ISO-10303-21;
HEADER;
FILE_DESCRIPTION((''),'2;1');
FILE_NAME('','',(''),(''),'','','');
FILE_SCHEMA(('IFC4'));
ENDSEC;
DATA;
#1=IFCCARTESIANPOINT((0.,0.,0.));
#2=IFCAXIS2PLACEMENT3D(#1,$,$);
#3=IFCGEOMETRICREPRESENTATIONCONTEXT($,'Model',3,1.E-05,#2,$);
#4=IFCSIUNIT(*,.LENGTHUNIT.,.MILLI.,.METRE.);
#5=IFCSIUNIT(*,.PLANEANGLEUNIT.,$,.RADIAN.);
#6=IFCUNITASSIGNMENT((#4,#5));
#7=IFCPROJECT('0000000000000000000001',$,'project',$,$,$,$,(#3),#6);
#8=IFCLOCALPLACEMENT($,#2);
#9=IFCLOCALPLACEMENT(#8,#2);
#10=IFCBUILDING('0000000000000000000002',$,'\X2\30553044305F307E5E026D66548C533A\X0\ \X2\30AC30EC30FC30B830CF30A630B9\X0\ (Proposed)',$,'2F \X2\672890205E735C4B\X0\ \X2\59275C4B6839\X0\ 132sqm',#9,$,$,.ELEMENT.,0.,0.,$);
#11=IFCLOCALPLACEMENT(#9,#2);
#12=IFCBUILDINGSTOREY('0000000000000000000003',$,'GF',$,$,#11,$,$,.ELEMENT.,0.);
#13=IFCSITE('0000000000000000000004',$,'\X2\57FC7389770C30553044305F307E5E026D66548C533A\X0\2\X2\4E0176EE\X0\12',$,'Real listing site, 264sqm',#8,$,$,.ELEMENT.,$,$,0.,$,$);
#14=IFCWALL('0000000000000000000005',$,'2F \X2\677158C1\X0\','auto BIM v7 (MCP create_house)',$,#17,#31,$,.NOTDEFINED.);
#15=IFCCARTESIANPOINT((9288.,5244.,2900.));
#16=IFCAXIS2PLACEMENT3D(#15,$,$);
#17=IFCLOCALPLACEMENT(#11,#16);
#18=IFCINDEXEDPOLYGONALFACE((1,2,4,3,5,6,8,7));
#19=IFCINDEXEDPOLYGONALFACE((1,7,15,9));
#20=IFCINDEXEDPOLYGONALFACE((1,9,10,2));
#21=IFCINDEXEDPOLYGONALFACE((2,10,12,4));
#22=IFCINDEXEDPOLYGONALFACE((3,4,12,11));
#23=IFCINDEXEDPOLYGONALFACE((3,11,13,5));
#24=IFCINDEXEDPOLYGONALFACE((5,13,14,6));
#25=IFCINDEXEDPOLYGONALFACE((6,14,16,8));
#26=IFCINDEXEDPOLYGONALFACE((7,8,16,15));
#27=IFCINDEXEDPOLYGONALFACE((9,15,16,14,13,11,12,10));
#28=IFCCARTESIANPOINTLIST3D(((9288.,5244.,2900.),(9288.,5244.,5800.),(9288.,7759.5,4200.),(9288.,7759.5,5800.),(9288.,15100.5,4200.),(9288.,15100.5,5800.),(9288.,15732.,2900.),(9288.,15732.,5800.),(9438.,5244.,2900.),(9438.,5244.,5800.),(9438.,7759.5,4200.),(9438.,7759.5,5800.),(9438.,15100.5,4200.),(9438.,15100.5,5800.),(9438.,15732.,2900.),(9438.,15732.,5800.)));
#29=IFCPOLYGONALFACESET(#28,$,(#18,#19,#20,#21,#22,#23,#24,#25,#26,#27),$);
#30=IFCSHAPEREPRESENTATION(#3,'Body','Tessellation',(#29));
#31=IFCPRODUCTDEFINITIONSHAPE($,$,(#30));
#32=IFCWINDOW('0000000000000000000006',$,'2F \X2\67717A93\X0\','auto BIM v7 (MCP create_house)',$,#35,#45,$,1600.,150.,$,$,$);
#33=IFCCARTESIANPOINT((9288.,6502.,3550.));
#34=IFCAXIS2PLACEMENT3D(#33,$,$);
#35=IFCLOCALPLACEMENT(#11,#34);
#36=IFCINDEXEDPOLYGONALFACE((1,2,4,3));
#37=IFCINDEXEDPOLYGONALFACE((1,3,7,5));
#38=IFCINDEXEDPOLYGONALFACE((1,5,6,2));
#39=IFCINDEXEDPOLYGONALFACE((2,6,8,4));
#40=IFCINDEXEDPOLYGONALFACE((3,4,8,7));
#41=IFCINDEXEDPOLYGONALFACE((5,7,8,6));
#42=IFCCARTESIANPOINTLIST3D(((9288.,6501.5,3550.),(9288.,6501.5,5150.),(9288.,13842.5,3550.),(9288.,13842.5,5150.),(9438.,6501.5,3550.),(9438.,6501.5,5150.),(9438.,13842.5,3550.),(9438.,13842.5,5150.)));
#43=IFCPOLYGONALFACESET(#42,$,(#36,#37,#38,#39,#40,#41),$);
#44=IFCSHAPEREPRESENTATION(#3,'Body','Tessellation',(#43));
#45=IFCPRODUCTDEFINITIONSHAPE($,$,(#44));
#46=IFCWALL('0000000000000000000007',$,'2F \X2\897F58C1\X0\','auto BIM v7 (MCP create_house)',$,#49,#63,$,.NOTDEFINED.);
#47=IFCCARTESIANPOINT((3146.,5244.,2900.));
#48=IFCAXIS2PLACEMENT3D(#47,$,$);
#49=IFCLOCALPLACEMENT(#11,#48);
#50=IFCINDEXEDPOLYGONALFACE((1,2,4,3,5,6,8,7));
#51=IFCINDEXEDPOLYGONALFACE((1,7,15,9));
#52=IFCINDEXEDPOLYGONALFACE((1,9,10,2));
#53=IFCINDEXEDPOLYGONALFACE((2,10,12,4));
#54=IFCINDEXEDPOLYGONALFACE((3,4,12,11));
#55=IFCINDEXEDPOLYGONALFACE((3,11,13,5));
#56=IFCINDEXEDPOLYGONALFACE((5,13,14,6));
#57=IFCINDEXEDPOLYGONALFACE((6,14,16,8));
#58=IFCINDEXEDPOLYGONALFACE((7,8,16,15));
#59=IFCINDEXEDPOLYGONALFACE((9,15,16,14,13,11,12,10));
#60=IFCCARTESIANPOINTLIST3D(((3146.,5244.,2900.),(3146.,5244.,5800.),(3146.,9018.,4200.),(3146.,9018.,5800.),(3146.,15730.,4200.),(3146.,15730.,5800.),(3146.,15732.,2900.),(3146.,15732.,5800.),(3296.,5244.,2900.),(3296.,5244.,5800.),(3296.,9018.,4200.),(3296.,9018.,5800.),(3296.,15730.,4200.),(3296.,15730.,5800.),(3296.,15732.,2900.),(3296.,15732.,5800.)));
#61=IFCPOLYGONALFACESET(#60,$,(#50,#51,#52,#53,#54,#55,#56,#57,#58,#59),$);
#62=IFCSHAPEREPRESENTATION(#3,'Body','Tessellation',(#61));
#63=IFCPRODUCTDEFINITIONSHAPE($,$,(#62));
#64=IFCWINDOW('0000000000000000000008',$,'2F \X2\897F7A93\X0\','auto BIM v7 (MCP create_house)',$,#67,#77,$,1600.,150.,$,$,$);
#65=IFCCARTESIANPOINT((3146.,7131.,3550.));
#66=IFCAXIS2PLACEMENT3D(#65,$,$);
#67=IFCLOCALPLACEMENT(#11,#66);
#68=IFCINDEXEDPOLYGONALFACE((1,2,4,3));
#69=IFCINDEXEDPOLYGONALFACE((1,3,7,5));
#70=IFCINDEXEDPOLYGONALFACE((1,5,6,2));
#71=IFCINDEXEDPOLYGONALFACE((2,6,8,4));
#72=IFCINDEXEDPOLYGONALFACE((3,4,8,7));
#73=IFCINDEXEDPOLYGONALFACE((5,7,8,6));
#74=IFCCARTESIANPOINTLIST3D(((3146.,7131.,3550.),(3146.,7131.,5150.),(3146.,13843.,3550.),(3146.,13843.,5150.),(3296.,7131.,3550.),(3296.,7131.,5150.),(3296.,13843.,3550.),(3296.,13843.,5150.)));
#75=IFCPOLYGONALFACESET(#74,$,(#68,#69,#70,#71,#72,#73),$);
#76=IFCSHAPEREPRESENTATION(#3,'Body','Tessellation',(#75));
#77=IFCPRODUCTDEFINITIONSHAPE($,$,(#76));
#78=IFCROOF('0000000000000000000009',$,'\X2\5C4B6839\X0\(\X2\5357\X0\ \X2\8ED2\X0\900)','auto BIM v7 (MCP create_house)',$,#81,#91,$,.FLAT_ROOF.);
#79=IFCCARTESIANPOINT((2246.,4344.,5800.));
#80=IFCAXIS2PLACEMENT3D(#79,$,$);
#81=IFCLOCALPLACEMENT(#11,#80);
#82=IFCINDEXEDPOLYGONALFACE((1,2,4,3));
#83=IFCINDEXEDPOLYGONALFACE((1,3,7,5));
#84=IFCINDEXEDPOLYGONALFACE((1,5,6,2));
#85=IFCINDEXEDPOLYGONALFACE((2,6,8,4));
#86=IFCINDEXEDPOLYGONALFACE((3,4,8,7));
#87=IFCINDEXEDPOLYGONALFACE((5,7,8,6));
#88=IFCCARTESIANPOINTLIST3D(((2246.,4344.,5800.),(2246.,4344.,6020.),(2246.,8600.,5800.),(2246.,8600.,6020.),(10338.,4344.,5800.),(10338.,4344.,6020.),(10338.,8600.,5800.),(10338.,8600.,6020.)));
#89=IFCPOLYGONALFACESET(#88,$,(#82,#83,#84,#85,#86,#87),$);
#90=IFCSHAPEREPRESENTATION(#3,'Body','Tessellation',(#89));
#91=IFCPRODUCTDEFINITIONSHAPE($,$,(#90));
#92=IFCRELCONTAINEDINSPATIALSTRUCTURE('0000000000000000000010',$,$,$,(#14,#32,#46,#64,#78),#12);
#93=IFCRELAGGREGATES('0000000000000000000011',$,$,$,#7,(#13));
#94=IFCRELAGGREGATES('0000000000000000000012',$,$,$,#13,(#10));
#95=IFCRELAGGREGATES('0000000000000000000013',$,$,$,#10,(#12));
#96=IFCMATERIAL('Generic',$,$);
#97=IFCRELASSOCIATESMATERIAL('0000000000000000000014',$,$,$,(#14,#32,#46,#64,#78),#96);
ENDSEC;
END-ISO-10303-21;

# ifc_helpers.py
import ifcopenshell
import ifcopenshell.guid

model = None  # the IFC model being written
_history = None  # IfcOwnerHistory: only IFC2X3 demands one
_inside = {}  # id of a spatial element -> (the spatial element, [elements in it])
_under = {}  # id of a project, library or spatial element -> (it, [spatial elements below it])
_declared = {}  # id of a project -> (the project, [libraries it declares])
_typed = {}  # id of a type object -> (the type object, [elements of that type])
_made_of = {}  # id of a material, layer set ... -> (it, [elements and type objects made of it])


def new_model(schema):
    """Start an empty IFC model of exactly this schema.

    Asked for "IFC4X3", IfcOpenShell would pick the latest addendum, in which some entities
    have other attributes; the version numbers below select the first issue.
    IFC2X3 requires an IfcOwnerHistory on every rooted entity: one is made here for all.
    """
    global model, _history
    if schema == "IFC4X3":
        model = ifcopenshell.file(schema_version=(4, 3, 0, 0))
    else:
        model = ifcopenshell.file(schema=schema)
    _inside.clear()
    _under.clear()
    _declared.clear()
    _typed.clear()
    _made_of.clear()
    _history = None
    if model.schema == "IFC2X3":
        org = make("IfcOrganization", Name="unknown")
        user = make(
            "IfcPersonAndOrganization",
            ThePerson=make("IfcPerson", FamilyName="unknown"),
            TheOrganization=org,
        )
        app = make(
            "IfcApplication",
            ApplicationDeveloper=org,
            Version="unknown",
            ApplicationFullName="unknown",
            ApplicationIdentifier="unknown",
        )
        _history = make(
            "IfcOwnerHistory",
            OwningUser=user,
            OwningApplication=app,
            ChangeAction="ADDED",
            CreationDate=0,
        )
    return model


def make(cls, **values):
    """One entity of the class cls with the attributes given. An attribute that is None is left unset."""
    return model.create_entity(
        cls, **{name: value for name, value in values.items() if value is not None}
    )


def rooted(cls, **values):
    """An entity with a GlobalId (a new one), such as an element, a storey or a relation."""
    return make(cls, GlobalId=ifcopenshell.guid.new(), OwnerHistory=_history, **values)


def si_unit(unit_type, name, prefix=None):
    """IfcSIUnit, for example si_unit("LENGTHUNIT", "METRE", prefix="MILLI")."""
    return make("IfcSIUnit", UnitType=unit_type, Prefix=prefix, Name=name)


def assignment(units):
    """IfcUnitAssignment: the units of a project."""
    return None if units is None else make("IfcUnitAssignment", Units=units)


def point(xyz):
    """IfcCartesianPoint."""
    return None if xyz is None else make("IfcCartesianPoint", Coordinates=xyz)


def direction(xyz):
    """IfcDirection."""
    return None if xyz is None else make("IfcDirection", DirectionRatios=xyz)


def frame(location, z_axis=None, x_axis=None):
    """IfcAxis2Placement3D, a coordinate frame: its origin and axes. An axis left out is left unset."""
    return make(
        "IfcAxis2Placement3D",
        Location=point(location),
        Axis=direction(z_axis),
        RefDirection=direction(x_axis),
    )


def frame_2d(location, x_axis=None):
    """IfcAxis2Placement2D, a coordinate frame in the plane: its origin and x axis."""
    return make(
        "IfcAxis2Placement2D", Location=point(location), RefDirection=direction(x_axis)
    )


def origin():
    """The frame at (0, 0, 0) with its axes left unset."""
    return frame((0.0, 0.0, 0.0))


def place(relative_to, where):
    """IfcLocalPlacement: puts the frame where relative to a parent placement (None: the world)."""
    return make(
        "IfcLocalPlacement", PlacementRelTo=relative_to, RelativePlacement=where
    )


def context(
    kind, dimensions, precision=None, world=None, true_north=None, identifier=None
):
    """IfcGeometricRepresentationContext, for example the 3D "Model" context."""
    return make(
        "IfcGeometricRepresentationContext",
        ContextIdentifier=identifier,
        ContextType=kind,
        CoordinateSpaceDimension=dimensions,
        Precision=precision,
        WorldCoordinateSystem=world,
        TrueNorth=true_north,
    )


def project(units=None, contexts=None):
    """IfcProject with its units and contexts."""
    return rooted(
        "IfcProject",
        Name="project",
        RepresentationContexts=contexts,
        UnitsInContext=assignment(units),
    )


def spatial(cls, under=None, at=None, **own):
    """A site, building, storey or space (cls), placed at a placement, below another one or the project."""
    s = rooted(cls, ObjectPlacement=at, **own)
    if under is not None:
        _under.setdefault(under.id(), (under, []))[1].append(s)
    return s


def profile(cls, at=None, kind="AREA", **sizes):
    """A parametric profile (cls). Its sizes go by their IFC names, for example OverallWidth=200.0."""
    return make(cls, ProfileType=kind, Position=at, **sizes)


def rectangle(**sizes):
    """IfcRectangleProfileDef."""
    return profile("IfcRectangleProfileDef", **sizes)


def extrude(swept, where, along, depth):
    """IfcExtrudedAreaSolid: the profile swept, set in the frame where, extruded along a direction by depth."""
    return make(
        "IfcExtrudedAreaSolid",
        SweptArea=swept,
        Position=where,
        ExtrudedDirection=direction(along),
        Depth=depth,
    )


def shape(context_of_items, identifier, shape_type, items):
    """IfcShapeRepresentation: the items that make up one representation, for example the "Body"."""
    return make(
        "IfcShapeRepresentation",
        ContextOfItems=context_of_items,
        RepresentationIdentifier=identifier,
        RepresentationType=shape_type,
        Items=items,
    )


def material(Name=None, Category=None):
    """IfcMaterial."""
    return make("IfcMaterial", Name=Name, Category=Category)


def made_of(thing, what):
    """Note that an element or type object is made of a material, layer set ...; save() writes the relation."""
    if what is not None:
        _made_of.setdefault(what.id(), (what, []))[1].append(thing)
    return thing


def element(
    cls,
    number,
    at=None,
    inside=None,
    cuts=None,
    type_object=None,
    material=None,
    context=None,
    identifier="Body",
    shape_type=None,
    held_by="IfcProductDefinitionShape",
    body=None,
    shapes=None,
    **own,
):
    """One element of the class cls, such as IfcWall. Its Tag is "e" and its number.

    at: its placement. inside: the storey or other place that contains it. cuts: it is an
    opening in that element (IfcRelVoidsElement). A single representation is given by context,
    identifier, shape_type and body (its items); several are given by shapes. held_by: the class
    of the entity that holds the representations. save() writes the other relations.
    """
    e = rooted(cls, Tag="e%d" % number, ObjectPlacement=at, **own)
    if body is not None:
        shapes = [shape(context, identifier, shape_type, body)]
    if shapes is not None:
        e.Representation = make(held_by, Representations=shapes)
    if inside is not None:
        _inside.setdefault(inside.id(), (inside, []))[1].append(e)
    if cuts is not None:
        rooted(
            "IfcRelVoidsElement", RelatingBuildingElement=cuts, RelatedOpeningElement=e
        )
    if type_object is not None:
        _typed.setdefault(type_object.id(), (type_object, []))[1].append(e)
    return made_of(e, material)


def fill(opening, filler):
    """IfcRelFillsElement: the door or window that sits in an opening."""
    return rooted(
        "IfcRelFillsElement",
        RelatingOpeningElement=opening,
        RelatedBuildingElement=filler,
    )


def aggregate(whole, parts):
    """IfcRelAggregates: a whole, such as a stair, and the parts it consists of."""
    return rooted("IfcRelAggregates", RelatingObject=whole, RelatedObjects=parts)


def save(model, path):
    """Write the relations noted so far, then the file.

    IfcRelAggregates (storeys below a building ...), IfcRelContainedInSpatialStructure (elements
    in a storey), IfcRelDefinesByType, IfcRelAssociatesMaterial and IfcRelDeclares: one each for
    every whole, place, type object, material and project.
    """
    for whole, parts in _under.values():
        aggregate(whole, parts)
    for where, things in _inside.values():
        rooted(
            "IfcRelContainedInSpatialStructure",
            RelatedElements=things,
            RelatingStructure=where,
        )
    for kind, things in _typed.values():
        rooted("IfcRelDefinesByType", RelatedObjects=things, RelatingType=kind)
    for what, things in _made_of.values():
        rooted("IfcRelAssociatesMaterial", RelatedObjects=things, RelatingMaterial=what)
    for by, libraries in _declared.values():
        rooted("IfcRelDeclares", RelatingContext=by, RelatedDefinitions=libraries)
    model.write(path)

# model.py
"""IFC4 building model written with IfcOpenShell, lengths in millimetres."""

from ifc_helpers import new_model, si_unit, frame, frame_2d, origin, place, context, project, spatial, rectangle, extrude, material, element, fill, save


model = new_model("IFC4")

# Units and contexts
model_context = context("Model", 3, precision=1e-05, world=origin())
ifc_project = project(units=[si_unit("LENGTHUNIT", "METRE", prefix="MILLI"), si_unit("PLANEANGLEUNIT", "RADIAN")], contexts=[model_context])

# Site, building, storey
site_placement = place(None, origin())
site = spatial("IfcSite", under=ifc_project, at=site_placement, Name="埼玉県さいたま市浦和区2丁目12", ObjectType="Real listing site, 264sqm", CompositionType="ELEMENT", RefElevation=0.0)
building_placement = place(site_placement, origin())
building = spatial("IfcBuilding", under=site, at=building_placement, Name="さいたま市浦和区 ガレージハウス (Proposed)", ObjectType="2F 木造平屋 大屋根 132sqm", CompositionType="ELEMENT", ElevationOfRefHeight=0.0, ElevationOfTerrain=0.0)
storey_placement = place(building_placement, origin())
storey = spatial("IfcBuildingStorey", under=building, at=storey_placement, Name="GF", CompositionType="ELEMENT", Elevation=0.0)

# Shared definitions
ifc_material = material(Name="Generic")

# Walls, openings, windows
wall_1_placement = place(storey_placement, frame((9288.0, 5244.0, 2900.0)))
wall_1 = element("IfcWall", 1, at=wall_1_placement, inside=storey, material=ifc_material, Name="2F 東壁", Description="auto BIM v7 (MCP create_house)", PredefinedType="NOTDEFINED", context=model_context, shape_type="SweptSolid", body=[
    extrude(rectangle(XDim=150.0, YDim=10488.0, at=frame_2d((75.0, 5244.0))), frame((9288.0, 5244.0, 2900.0)), (0.0, 0.0, 1.0), 2900.0),
])
opening_1_placement = place(storey_placement, frame((9288.0, 6502.0, 3550.0)))
opening_1 = element("IfcOpeningElement", 2, at=opening_1_placement, cuts=wall_1, PredefinedType="NOTDEFINED", context=model_context, shape_type="SweptSolid", body=[
    extrude(rectangle(XDim=150.0, YDim=7341.0, at=frame_2d((75.0, 3670.0))), frame((9288.0, 6502.0, 3550.0)), (0.0, 0.0, 1.0), 1600.0),
])
window_1_placement = place(storey_placement, frame((9288.0, 6502.0, 3550.0)))
window_1 = element("IfcWindow", 3, at=window_1_placement, inside=storey, material=ifc_material, Name="2F 東窓", Description="auto BIM v7 (MCP create_house)", OverallHeight=1600.0, OverallWidth=150.0, context=model_context, shape_type="SweptSolid", body=[
    extrude(rectangle(XDim=150.0, YDim=7341.0, at=frame_2d((75.0, 3670.0))), frame((9288.0, 6502.0, 3550.0)), (0.0, 0.0, 1.0), 1600.0),
])
fill(opening_1, window_1)
wall_2_placement = place(storey_placement, frame((3146.0, 5244.0, 2900.0)))
wall_2 = element("IfcWall", 4, at=wall_2_placement, inside=storey, material=ifc_material, Name="2F 西壁", Description="auto BIM v7 (MCP create_house)", PredefinedType="NOTDEFINED", context=model_context, shape_type="SweptSolid", body=[
    extrude(rectangle(XDim=150.0, YDim=10488.0, at=frame_2d((75.0, 5244.0))), frame((3146.0, 5244.0, 2900.0)), (0.0, 0.0, 1.0), 2900.0),
])
opening_2_placement = place(storey_placement, frame((3146.0, 7131.0, 3550.0)))
opening_2 = element("IfcOpeningElement", 5, at=opening_2_placement, cuts=wall_2, PredefinedType="NOTDEFINED", context=model_context, shape_type="SweptSolid", body=[
    extrude(rectangle(XDim=150.0, YDim=6712.0, at=frame_2d((75.0, 3356.0))), frame((3146.0, 7131.0, 3550.0)), (0.0, 0.0, 1.0), 1600.0),
])
window_2_placement = place(storey_placement, frame((3146.0, 7131.0, 3550.0)))
window_2 = element("IfcWindow", 6, at=window_2_placement, inside=storey, material=ifc_material, Name="2F 西窓", Description="auto BIM v7 (MCP create_house)", OverallHeight=1600.0, OverallWidth=150.0, context=model_context, shape_type="SweptSolid", body=[
    extrude(rectangle(XDim=150.0, YDim=6712.0, at=frame_2d((75.0, 3356.0))), frame((3146.0, 7131.0, 3550.0)), (0.0, 0.0, 1.0), 1600.0),
])
fill(opening_2, window_2)

# Roof
roof_1_placement = place(storey_placement, frame((2246.0, 4344.0, 5800.0)))
element("IfcRoof", 7, at=roof_1_placement, inside=storey, material=ifc_material, Name="屋根(南 軒900)", Description="auto BIM v7 (MCP create_house)", PredefinedType="FLAT_ROOF", context=model_context, shape_type="SweptSolid", body=[
    extrude(rectangle(XDim=8092.0, YDim=4256.0, at=frame_2d((4046.0, 2128.0))), frame((2246.0, 4344.0, 5800.0)), (0.0, 0.0, 1.0), 220.0),
])

save(model, "model.ifc")
